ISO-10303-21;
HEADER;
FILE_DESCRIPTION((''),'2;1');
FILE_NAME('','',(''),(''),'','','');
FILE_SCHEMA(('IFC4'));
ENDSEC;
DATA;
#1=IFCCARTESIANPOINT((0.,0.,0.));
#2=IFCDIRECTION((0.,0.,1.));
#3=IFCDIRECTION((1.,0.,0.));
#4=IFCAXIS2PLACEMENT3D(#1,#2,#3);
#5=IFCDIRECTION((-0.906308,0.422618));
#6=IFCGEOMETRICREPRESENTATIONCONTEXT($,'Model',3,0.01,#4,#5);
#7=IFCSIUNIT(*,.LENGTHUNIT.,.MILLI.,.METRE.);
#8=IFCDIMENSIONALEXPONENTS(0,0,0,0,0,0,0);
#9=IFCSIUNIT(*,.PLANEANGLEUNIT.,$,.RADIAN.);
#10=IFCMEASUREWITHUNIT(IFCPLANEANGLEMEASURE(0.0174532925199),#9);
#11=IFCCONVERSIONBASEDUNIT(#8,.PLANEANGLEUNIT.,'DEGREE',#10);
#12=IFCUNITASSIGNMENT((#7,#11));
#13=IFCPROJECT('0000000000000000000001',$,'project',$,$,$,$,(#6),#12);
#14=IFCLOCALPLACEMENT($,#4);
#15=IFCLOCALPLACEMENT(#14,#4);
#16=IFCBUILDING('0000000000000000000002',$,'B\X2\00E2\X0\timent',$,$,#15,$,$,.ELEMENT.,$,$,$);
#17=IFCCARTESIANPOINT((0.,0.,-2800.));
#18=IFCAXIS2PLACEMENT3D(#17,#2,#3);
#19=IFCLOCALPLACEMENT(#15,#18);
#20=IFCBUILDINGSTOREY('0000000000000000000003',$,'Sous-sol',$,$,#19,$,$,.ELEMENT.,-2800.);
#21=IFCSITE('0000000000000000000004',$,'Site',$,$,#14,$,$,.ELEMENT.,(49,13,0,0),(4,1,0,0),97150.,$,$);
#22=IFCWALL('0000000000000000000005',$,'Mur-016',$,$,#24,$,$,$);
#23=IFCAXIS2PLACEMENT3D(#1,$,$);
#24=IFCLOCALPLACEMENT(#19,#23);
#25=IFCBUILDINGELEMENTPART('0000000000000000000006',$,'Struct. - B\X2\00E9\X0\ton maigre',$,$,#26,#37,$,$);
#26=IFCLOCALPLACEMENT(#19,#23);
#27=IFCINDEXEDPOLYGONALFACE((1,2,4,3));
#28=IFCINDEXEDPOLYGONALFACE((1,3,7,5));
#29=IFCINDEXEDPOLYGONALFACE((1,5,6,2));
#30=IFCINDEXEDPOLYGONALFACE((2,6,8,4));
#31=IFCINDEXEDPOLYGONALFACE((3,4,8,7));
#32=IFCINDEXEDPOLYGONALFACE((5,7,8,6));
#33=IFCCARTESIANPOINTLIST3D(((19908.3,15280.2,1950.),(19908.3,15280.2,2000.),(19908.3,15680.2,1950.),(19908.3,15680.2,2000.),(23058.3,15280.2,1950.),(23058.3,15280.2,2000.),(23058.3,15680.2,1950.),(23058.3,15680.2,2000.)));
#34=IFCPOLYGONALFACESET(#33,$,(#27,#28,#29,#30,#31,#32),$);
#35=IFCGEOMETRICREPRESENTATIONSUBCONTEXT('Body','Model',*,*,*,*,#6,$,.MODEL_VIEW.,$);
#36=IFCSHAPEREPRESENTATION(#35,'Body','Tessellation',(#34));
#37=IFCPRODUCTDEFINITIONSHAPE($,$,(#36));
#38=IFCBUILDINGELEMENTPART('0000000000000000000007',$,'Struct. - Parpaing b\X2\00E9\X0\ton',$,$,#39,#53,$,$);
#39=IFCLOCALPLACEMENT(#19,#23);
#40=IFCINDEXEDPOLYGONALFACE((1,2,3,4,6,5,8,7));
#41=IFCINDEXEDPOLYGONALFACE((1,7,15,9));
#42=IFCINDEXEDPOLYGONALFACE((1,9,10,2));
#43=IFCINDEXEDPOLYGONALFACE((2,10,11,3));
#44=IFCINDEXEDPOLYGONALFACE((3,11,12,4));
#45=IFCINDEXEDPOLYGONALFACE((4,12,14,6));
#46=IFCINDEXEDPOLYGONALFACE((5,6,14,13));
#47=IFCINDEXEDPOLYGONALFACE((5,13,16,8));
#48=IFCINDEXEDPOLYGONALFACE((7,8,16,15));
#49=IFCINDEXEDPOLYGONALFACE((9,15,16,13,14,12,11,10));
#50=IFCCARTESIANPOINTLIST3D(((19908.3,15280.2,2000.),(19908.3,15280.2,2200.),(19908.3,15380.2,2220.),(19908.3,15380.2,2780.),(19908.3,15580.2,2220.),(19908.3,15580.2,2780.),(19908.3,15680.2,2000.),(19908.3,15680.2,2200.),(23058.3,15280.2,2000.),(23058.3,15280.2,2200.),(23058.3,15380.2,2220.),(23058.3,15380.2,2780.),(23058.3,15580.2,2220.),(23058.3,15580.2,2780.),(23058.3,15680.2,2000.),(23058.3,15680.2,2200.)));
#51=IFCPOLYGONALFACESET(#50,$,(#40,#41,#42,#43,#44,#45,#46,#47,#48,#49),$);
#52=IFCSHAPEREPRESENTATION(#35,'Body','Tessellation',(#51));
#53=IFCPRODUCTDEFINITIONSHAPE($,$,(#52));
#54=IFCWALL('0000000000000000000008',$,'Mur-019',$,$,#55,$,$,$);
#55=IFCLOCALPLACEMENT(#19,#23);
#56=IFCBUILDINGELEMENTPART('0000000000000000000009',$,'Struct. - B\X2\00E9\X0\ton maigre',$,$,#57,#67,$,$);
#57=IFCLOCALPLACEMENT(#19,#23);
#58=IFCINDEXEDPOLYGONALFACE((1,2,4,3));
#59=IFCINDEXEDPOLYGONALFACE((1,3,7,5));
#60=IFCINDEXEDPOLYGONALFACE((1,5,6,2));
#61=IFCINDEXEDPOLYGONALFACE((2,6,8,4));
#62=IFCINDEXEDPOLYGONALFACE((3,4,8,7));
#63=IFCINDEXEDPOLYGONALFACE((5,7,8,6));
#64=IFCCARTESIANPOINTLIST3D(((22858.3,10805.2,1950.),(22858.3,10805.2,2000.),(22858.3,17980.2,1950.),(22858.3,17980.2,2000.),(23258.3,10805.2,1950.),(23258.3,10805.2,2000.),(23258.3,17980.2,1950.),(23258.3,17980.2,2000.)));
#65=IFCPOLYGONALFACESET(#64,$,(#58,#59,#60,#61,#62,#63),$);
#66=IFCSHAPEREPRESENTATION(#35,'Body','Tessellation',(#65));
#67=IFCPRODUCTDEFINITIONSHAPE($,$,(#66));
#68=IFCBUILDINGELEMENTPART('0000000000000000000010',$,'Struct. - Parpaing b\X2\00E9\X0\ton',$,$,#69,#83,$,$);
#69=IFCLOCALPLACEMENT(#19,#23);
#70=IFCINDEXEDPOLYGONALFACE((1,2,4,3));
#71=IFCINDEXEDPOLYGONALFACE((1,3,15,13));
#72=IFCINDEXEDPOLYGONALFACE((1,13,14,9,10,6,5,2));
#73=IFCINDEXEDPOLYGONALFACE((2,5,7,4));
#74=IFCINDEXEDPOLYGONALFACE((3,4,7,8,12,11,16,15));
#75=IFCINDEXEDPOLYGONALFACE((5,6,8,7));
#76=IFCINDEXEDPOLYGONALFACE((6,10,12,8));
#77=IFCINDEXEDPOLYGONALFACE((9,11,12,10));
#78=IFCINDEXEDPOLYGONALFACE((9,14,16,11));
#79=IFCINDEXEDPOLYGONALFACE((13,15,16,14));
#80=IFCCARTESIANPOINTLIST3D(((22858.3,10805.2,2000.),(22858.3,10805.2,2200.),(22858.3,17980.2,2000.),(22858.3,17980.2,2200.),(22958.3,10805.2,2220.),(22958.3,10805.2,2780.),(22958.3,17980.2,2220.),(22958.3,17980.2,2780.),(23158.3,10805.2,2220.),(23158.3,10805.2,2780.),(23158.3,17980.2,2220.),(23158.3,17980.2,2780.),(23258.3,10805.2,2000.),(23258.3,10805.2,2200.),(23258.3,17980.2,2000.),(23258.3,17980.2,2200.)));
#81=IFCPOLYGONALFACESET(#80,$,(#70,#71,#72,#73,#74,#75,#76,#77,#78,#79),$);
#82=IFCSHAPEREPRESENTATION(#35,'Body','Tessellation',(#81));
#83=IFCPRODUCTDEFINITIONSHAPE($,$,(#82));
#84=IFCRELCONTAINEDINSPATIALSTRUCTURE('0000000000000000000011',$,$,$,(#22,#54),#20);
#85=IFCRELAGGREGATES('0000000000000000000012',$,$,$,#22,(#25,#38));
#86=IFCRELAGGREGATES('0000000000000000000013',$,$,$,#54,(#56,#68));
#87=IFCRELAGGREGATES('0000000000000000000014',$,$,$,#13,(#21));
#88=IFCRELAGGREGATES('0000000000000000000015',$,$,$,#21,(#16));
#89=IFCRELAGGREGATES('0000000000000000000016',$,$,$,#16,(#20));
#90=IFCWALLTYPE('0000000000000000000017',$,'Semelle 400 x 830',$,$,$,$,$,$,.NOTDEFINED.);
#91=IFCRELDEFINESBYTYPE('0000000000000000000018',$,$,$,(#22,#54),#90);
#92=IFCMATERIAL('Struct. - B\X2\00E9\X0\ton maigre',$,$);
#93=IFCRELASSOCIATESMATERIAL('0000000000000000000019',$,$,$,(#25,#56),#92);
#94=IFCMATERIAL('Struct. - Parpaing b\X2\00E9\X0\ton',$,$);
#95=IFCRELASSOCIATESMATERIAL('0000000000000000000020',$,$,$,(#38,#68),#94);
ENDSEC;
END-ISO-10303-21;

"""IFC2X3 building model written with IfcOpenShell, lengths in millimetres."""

from ifc_helpers import new_model, entity, si_unit, converted_unit, direction, frame, origin_with_axes, place, context, subcontext, project, spatial, polyline, outline, extrude, material, type_object, element, aggregate, save


model = new_model("IFC2X3")

# Units and contexts
model_context = context("Model", 3, precision=0.01, world=origin_with_axes(), true_north=direction((-0.906308, 0.422618)))
body_context = subcontext(model_context, "Body", "Model", "MODEL_VIEW")
ifc_project = project(units=[si_unit("LENGTHUNIT", "METRE", prefix="MILLI"), converted_unit("PLANEANGLEUNIT", "DEGREE", entity("IfcPlaneAngleMeasure", 0.0174532925199), si_unit("PLANEANGLEUNIT", "RADIAN"), dimensions=[0, 0, 0, 0, 0, 0, 0])], contexts=[model_context])

# Site, building, storey
site_placement = place(None, origin_with_axes())
site = spatial("IfcSite", under=ifc_project, at=site_placement, Name="Site", CompositionType="ELEMENT", RefLatitude=(49, 13, 0, 0), RefLongitude=(4, 1, 0, 0), RefElevation=97150.0)
building_placement = place(site_placement, origin_with_axes())
building = spatial("IfcBuilding", under=site, at=building_placement, Name="Bâtiment", CompositionType="ELEMENT")
storey_placement = place(building_placement, frame((0.0, 0.0, -2800.0), z_axis=(0.0, 0.0, 1.0), x_axis=(1.0, 0.0, 0.0)))
storey = spatial("IfcBuildingStorey", under=building, at=storey_placement, Name="Sous-sol", CompositionType="ELEMENT", Elevation=-2800.0)

# Walls, building element parts
wall_type_1 = type_object("IfcWallType", Name="Semelle 400 x 830", PredefinedType="NOTDEFINED")
wall_1_placement = place(storey_placement, frame((19908.3, 15480.2, 2000.0), z_axis=(0.0, 0.0, 1.0), x_axis=(1.0, 0.0, 0.0)))
wall_1 = element("IfcWall", 1, at=wall_1_placement, inside=storey, type_object=wall_type_1, Name="Mur-016")
ifc_material_1 = material(Name="Struct. - Béton maigre")
building_element_part_1_placement = place(wall_1_placement, origin_with_axes())
building_element_part_1 = element("IfcBuildingElementPart", 2, at=building_element_part_1_placement, material=ifc_material_1, Name="Struct. - Béton maigre", context=body_context, shape_type="SweptSolid", body=[
    extrude(outline(polyline([(-200.0, 0.0), (-200.0, -50.0), (200.0, -50.0), (200.0, 0.0), (-200.0, 0.0)])), frame((0.0, 0.0, 0.0), z_axis=(-1.0, 0.0, 0.0), x_axis=(0.0, -1.0, 0.0)), (0.0, 0.0, -1.0), 3150.0),
])
ifc_material_2 = material(Name="Struct. - Parpaing béton")
building_element_part_2_placement = place(wall_1_placement, origin_with_axes())
building_element_part_2 = element("IfcBuildingElementPart", 3, at=building_element_part_2_placement, material=ifc_material_2, Name="Struct. - Parpaing béton", context=body_context, shape_type="SweptSolid", body=[
    extrude(outline(polyline([(-200.0, 200.0), (-200.0, 0.0), (200.0, 0.0), (200.0, 200.0), (100.0, 220.0), (100.0, 780.0), (-100.0, 780.0), (-100.0, 220.0), (-200.0, 200.0)])), frame((0.0, 0.0, 0.0), z_axis=(-1.0, 0.0, 0.0), x_axis=(0.0, -1.0, 0.0)), (0.0, 0.0, -1.0), 3150.0),
])
aggregate(wall_1, [building_element_part_1, building_element_part_2])
wall_2_placement = place(storey_placement, frame((23058.3, 10805.2, 2000.0), z_axis=(0.0, 0.0, 1.0), x_axis=(0.0, 1.0, 0.0)))
wall_2 = element("IfcWall", 4, at=wall_2_placement, inside=storey, type_object=wall_type_1, Name="Mur-019")
building_element_part_3_placement = place(wall_2_placement, origin_with_axes())
building_element_part_3 = element("IfcBuildingElementPart", 5, at=building_element_part_3_placement, material=ifc_material_1, Name="Struct. - Béton maigre", context=body_context, shape_type="SweptSolid", body=[
    extrude(outline(polyline([(-200.0, 0.0), (-200.0, -50.0), (200.0, -50.0), (200.0, 0.0), (-200.0, 0.0)])), frame((0.0, 0.0, 0.0), z_axis=(-1.0, 0.0, 0.0), x_axis=(0.0, -1.0, 0.0)), (0.0, 0.0, -1.0), 7175.0),
])
building_element_part_4_placement = place(wall_2_placement, origin_with_axes())
building_element_part_4 = element("IfcBuildingElementPart", 6, at=building_element_part_4_placement, material=ifc_material_2, Name="Struct. - Parpaing béton", context=body_context, shape_type="SweptSolid", body=[
    extrude(outline(polyline([(-200.0, 200.0), (-200.0, 0.0), (200.0, 0.0), (200.0, 200.0), (100.0, 220.0), (100.0, 780.0), (-100.0, 780.0), (-100.0, 220.0), (-200.0, 200.0)])), frame((0.0, 0.0, 0.0), z_axis=(-1.0, 0.0, 0.0), x_axis=(0.0, -1.0, 0.0)), (0.0, 0.0, -1.0), 7175.0),
])
aggregate(wall_2, [building_element_part_3, building_element_part_4])

save(model, "model.ifc")
